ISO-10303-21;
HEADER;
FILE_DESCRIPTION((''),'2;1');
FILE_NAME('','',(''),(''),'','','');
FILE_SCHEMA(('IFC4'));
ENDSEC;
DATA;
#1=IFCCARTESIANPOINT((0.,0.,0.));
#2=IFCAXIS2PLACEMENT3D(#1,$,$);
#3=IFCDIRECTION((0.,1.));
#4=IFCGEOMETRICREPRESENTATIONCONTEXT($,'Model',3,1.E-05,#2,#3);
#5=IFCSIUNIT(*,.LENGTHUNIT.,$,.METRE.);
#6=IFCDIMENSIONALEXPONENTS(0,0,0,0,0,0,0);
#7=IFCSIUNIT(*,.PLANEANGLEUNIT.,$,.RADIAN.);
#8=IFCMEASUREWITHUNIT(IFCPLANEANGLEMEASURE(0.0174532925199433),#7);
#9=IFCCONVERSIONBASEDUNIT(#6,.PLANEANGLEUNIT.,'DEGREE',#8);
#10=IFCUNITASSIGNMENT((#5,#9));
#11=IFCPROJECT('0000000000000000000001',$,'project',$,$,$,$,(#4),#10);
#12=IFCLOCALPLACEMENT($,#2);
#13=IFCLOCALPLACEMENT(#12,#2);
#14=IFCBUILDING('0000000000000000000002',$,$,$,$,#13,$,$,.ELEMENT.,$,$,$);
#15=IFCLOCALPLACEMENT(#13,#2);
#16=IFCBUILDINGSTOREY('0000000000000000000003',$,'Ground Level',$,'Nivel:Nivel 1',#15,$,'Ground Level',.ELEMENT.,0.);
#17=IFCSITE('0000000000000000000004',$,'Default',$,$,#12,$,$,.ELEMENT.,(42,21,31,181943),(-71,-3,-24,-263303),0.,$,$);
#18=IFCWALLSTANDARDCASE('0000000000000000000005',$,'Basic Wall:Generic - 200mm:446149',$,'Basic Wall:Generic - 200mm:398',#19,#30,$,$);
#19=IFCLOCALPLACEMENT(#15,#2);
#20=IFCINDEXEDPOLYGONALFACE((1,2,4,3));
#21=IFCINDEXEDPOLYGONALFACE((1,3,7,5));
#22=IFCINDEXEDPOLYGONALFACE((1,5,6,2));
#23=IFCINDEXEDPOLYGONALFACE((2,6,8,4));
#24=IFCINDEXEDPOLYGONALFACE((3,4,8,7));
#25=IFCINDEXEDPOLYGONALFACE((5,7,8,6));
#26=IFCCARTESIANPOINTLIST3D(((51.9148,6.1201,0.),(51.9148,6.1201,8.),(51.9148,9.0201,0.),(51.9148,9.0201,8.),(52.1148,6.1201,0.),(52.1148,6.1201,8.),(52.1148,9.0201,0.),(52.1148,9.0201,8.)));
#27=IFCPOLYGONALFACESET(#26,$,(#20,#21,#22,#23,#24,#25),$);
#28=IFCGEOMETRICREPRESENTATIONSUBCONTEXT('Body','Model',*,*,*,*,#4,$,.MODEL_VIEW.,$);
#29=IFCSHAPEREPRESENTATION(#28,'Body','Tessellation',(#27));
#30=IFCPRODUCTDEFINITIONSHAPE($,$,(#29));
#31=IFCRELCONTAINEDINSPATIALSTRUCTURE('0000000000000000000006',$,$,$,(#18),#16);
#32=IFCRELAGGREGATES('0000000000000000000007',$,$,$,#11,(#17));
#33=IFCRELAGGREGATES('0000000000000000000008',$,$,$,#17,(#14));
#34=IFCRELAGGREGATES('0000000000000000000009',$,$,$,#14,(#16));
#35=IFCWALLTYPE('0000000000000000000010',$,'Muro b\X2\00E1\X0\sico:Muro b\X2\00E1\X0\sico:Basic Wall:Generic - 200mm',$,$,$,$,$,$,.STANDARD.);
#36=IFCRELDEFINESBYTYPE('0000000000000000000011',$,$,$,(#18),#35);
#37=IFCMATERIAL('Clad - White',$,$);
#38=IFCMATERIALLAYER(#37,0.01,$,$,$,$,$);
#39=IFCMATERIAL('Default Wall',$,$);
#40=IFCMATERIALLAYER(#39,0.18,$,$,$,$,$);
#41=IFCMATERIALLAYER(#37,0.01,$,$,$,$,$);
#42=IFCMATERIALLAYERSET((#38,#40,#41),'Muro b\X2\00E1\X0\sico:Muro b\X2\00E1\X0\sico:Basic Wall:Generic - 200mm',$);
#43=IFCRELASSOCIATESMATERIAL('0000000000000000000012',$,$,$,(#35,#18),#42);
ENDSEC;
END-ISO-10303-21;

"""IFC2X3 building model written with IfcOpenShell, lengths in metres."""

from ifc_helpers import new_model, entity, si_unit, converted_unit, direction, frame, frame_2d, origin, place, context, subcontext, project, spatial, rectangle, extrude, material, layer, layer_set, layer_usage, type_object, element, save


model = new_model("IFC2X3")

# Units and contexts
model_context = context("Model", 3, precision=1e-05, world=origin(), true_north=direction((0.0, 1.0)))
body_context = subcontext(model_context, "Body", "Model", "MODEL_VIEW")
ifc_project = project(units=[si_unit("LENGTHUNIT", "METRE"), converted_unit("PLANEANGLEUNIT", "DEGREE", entity("IfcPlaneAngleMeasure", 0.0174532925199433), si_unit("PLANEANGLEUNIT", "RADIAN"), dimensions=[0, 0, 0, 0, 0, 0, 0])], contexts=[model_context])

# Site, building, storey
site_placement = place(None, origin())
site = spatial("IfcSite", under=ifc_project, at=site_placement, Name="Default", CompositionType="ELEMENT", RefLatitude=(42, 21, 31, 181943), RefLongitude=(-71, -3, -24, -263303), RefElevation=0.0)
building_placement = place(site_placement, origin())
building = spatial("IfcBuilding", under=site, at=building_placement, CompositionType="ELEMENT")
storey_placement = place(building_placement, origin())
storey = spatial("IfcBuildingStorey", under=building, at=storey_placement, Name="Ground Level", ObjectType="Nivel:Nivel 1", LongName="Ground Level", CompositionType="ELEMENT", Elevation=0.0)

# Shared definitions
ifc_material_1 = material(Name="Default Wall")

# Wall
ifc_material_2 = material(Name="Clad - White")
ifc_layer_1 = layer(ifc_material_2, 0.01)
ifc_layer_2 = layer(ifc_material_1, 0.18)
ifc_layer_3 = layer(ifc_material_2, 0.01)
ifc_layer_set_1 = layer_set([ifc_layer_1, ifc_layer_2, ifc_layer_3], Name="Muro básico:Muro básico:Basic Wall:Generic - 200mm")
wall_type_1 = type_object("IfcWallType", Name="Muro básico:Muro básico:Basic Wall:Generic - 200mm", PredefinedType="STANDARD", material=ifc_layer_set_1)
ifc_layer_usage_1 = layer_usage(ifc_layer_set_1, "AXIS2", "NEGATIVE", 0.1)
wall_1_placement = place(storey_placement, frame((52.0148, 9.0201, 0.0), z_axis=(0.0, 0.0, 1.0), x_axis=(0.0, -1.0, 0.0)))
element("IfcWallStandardCase", 1, at=wall_1_placement, inside=storey, type_object=wall_type_1, material=ifc_layer_usage_1, Name="Basic Wall:Generic - 200mm:446149", ObjectType="Basic Wall:Generic - 200mm:398", context=body_context, shape_type="SweptSolid", body=[
    extrude(rectangle(XDim=2.9, YDim=0.2, at=frame_2d((1.45, 0.0), x_axis=(-1.0, 0.0))), origin(), (0.0, 0.0, 1.0), 8.0),
])

save(model, "model.ifc")
